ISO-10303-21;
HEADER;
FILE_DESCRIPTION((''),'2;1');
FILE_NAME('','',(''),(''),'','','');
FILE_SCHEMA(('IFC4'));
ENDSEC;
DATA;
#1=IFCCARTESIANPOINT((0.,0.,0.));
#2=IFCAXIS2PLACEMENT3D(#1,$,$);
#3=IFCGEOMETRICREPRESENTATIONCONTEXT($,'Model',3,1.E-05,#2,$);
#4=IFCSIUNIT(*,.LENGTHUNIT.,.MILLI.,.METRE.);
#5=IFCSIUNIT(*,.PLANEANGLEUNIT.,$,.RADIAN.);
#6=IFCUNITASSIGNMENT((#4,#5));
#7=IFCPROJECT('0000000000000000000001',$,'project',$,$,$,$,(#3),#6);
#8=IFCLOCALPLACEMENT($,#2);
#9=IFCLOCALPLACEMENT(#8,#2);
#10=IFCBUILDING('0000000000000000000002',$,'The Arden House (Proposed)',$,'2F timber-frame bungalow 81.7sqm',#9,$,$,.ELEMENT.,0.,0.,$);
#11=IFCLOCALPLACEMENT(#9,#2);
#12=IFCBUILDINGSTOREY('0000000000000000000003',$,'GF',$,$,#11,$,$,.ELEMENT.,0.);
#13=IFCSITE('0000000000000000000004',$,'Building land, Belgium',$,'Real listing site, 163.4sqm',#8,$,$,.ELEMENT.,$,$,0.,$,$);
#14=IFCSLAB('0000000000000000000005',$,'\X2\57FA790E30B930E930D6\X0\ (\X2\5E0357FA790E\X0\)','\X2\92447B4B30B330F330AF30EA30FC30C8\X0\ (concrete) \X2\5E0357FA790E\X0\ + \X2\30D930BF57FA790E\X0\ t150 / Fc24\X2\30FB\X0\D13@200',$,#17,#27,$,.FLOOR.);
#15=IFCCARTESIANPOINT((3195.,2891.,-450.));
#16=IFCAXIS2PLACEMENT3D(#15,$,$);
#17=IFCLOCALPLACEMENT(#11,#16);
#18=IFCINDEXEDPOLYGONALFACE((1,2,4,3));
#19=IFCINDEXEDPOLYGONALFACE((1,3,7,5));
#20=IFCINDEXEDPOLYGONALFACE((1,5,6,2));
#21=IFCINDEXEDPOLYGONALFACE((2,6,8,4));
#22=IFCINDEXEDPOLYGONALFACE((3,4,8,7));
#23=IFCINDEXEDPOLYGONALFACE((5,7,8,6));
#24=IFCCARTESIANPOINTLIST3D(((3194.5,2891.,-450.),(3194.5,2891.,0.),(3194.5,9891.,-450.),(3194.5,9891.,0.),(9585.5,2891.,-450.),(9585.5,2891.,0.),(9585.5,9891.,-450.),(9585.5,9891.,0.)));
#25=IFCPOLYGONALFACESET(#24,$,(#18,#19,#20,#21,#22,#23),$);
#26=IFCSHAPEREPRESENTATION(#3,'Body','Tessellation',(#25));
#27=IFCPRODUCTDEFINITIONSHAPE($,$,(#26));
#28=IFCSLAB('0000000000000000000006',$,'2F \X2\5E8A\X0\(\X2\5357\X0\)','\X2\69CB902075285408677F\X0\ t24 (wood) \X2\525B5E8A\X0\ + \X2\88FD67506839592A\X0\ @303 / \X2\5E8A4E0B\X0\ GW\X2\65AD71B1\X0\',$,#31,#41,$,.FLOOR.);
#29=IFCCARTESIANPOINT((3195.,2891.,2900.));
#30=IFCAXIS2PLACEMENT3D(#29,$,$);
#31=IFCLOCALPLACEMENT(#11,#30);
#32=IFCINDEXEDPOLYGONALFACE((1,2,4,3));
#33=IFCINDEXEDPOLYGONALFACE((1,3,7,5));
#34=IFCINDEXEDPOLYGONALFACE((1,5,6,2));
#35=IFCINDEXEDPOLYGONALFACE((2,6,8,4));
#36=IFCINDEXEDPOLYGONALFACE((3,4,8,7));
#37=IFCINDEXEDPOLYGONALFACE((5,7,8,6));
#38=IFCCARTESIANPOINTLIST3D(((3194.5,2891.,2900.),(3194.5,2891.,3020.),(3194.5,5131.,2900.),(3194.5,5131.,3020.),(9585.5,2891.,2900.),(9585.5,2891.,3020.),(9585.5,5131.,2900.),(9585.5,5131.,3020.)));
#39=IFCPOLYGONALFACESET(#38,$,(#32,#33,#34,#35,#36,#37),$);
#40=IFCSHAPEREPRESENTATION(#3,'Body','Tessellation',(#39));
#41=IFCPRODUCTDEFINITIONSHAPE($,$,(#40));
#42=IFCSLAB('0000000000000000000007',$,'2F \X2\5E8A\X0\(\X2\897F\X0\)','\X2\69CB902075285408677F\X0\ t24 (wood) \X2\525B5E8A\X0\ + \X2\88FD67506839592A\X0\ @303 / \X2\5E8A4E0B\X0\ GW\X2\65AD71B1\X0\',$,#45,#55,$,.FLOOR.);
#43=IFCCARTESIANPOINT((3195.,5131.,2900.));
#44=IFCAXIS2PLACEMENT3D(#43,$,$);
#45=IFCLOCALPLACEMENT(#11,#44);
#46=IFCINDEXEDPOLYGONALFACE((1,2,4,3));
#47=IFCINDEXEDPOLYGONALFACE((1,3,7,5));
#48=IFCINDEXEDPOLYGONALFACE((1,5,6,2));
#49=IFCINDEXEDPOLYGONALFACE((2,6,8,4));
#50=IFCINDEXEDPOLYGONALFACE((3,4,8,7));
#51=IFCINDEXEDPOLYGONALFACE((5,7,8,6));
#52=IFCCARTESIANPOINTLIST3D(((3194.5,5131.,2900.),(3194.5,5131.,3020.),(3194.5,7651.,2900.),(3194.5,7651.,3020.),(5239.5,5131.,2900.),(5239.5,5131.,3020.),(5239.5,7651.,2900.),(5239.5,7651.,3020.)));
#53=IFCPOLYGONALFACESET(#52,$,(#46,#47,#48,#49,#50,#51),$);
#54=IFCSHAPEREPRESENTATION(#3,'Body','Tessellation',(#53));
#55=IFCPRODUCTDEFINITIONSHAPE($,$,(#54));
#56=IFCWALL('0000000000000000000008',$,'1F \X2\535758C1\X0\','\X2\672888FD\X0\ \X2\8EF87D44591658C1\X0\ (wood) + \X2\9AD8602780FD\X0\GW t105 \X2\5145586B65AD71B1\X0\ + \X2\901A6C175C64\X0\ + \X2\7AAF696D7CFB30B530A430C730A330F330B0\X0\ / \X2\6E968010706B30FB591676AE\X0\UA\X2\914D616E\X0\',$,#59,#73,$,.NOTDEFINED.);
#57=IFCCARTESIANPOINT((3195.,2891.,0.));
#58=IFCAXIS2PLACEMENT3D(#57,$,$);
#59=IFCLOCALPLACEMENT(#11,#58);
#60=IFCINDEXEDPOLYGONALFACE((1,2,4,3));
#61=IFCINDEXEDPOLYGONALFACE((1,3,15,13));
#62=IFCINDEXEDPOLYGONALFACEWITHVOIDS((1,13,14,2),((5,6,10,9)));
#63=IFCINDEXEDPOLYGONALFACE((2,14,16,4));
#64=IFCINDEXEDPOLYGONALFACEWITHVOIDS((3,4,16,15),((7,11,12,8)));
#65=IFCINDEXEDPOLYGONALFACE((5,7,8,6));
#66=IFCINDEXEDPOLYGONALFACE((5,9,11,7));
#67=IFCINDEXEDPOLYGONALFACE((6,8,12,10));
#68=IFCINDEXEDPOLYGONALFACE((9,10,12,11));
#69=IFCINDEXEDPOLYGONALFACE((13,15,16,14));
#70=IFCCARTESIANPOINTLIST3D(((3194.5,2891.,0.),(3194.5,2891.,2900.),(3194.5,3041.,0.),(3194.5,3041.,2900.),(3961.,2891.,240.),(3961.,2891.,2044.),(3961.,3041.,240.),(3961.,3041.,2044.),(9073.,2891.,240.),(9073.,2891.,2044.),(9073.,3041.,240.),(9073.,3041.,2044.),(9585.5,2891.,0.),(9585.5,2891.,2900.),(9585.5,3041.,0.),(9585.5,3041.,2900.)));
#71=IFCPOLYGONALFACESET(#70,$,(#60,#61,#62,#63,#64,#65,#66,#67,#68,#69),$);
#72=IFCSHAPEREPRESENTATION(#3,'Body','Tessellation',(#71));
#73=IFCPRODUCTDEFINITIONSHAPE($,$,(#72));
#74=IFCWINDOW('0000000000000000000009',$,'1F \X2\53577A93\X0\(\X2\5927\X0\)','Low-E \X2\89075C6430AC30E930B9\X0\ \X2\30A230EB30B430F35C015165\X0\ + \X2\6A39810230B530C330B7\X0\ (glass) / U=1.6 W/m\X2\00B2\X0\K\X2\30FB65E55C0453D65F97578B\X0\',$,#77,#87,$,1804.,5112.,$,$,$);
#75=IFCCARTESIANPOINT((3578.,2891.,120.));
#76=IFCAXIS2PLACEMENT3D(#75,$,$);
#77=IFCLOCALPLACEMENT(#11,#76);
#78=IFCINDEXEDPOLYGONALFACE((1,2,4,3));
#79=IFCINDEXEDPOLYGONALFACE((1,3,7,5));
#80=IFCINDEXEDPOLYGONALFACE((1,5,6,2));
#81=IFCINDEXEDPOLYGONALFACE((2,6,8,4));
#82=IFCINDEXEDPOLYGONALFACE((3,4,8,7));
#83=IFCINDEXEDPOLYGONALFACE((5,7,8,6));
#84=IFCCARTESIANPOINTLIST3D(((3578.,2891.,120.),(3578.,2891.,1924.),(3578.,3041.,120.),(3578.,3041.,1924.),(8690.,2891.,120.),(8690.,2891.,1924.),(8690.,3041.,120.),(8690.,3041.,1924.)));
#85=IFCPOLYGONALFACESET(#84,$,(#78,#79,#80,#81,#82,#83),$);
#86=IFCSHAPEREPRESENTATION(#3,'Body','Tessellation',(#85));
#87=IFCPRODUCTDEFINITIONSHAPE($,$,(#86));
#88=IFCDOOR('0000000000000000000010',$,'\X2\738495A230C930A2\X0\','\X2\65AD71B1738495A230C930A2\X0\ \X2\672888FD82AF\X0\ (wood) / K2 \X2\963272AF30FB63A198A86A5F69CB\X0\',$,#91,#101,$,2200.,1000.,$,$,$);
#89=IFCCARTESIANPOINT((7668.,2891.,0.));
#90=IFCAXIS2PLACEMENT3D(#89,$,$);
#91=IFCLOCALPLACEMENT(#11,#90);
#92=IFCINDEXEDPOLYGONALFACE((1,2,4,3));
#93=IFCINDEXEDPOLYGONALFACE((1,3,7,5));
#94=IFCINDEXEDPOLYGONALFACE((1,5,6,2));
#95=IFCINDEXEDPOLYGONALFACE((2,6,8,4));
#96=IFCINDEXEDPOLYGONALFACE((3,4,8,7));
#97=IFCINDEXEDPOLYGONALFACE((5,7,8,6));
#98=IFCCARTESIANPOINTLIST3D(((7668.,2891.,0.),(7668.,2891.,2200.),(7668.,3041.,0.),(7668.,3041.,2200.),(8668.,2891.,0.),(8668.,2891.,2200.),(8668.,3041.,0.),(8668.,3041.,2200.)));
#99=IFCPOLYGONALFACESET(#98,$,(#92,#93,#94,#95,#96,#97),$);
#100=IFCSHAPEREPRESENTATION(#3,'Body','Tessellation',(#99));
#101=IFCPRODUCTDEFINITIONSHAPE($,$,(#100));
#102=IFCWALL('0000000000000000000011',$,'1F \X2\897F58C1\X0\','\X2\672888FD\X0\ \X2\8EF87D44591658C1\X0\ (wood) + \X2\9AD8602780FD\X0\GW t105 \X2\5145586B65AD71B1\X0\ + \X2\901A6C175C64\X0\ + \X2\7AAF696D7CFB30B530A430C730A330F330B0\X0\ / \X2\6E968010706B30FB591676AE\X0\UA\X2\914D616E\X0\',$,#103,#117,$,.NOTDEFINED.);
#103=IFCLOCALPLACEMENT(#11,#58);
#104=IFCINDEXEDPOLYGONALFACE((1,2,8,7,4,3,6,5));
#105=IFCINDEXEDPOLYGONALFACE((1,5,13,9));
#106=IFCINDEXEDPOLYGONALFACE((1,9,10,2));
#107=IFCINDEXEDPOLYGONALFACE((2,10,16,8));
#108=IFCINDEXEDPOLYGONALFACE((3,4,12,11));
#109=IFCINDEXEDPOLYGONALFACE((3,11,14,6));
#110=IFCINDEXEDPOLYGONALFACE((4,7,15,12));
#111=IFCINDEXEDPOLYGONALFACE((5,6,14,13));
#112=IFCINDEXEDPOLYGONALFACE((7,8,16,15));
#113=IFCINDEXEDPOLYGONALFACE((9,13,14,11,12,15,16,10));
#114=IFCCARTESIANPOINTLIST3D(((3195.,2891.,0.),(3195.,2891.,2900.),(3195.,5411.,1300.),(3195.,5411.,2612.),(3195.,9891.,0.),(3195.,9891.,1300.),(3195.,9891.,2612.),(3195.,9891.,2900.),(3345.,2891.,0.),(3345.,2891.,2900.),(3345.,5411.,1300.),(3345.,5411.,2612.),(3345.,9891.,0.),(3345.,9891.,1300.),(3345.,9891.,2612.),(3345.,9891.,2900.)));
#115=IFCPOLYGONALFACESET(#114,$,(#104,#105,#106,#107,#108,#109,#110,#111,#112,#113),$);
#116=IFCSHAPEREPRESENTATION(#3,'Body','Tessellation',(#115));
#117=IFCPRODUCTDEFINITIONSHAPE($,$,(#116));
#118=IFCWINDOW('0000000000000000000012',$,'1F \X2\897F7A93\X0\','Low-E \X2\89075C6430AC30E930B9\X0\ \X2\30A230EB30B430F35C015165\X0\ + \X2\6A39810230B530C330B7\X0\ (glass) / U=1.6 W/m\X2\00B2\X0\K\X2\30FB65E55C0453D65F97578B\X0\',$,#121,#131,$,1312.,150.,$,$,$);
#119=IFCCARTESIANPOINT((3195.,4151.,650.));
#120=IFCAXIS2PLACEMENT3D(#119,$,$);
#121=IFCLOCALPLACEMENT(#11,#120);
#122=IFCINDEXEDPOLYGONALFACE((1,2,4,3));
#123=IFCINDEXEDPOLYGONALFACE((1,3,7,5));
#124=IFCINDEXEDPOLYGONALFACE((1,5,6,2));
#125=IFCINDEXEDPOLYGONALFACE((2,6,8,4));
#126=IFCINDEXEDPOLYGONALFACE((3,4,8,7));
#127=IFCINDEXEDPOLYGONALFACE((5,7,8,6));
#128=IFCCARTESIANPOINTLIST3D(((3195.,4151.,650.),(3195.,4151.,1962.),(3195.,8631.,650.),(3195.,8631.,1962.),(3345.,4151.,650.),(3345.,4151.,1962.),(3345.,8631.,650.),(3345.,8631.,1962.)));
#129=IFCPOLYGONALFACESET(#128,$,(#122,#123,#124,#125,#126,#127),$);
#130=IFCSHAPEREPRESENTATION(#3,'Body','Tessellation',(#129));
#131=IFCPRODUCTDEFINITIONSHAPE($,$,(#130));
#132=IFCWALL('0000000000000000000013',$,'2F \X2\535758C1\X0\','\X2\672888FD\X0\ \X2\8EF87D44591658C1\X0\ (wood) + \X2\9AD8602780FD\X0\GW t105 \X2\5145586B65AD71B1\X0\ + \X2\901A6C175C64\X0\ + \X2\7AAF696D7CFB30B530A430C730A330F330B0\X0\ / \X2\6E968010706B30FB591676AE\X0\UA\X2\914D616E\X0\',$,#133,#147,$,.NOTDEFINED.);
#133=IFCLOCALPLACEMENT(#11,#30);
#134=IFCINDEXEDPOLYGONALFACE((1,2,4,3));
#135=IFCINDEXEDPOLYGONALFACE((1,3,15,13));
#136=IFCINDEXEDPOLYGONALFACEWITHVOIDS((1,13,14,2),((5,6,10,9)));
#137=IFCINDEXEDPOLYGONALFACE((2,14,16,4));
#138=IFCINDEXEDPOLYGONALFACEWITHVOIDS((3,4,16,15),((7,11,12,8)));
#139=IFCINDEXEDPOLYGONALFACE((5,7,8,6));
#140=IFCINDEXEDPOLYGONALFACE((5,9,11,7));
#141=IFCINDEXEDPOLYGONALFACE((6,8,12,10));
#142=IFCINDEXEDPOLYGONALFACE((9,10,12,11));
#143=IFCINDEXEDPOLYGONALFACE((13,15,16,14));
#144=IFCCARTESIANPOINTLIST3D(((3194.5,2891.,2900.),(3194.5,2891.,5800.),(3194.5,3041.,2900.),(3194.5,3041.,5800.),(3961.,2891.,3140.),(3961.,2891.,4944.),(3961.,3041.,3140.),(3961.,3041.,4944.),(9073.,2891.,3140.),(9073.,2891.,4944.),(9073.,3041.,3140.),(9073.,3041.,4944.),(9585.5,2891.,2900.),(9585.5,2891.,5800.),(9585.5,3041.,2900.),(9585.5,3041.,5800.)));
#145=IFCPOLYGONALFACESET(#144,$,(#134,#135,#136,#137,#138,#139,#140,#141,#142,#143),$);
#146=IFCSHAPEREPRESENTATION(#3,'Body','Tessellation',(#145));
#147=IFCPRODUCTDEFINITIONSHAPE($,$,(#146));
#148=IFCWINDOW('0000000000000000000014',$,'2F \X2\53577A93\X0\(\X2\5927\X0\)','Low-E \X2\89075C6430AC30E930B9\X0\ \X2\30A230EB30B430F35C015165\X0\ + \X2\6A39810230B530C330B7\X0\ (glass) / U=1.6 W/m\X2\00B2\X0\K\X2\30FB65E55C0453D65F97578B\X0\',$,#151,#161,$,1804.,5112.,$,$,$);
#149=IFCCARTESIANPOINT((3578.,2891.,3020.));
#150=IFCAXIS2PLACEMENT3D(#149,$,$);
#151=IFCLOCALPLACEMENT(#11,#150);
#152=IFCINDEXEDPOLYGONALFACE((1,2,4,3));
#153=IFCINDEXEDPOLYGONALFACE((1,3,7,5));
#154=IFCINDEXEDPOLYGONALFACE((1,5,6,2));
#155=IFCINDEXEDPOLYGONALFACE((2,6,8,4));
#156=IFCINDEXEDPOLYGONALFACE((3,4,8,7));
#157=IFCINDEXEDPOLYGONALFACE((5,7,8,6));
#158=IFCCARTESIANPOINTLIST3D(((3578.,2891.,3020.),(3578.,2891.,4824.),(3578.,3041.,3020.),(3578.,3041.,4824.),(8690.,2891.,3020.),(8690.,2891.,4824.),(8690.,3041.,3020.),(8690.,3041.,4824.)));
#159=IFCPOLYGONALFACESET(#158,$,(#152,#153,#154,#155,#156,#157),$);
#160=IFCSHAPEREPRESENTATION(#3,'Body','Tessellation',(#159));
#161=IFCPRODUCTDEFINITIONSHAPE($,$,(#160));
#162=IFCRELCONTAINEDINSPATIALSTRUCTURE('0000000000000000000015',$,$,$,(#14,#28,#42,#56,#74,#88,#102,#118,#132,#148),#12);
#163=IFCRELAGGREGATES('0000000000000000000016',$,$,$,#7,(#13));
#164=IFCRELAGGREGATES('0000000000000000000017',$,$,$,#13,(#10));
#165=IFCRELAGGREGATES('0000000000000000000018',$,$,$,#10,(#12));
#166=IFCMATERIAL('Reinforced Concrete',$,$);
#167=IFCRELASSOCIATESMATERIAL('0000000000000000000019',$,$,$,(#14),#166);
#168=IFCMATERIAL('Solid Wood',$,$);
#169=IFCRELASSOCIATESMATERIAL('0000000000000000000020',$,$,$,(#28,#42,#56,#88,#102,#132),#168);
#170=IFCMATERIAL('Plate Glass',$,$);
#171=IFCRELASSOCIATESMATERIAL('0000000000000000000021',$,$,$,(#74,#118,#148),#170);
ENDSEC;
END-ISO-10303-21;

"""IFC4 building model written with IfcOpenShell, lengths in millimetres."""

from ifc_helpers import new_model, si_unit, frame, frame_2d, origin, place, context, project, spatial, rectangle, extrude, material, element, fill, save


model = new_model("IFC4")

# Units and contexts
model_context = context("Model", 3, precision=1e-05, world=origin())
ifc_project = project(units=[si_unit("LENGTHUNIT", "METRE", prefix="MILLI"), si_unit("PLANEANGLEUNIT", "RADIAN")], contexts=[model_context])

# Site, building, storey
site_placement = place(None, origin())
site = spatial("IfcSite", under=ifc_project, at=site_placement, Name="Building land, Belgium", ObjectType="Real listing site, 163.4sqm", CompositionType="ELEMENT", RefElevation=0.0)
building_placement = place(site_placement, origin())
building = spatial("IfcBuilding", under=site, at=building_placement, Name="The Arden House (Proposed)", ObjectType="2F timber-frame bungalow 81.7sqm", CompositionType="ELEMENT", ElevationOfRefHeight=0.0, ElevationOfTerrain=0.0)
storey_placement = place(building_placement, origin())
storey = spatial("IfcBuildingStorey", under=building, at=storey_placement, Name="GF", CompositionType="ELEMENT", Elevation=0.0)

# Slabs
ifc_material_1 = material(Name="Reinforced Concrete")
slab_1_placement = place(storey_placement, frame((3195.0, 2891.0, -450.0)))
element("IfcSlab", 1, at=slab_1_placement, inside=storey, material=ifc_material_1, Name="基礎スラブ (布基礎)", Description="鉄筋コンクリート (concrete) 布基礎 + ベタ基礎 t150 / Fc24・D13@200", PredefinedType="FLOOR", context=model_context, shape_type="SweptSolid", body=[
    extrude(rectangle(XDim=6391.0, YDim=7000.0, at=frame_2d((3195.0, 3500.0))), frame((3195.0, 2891.0, -450.0)), (0.0, 0.0, 1.0), 450.0),
])
ifc_material_2 = material(Name="Solid Wood")
slab_2_placement = place(storey_placement, frame((3195.0, 2891.0, 2900.0)))
element("IfcSlab", 2, at=slab_2_placement, inside=storey, material=ifc_material_2, Name="2F 床(南)", Description="構造用合板 t24 (wood) 剛床 + 製材根太 @303 / 床下 GW断熱", PredefinedType="FLOOR", context=model_context, shape_type="SweptSolid", body=[
    extrude(rectangle(XDim=6391.0, YDim=2240.0, at=frame_2d((3195.0, 1120.0))), frame((3195.0, 2891.0, 2900.0)), (0.0, 0.0, 1.0), 120.0),
])
slab_3_placement = place(storey_placement, frame((3195.0, 5131.0, 2900.0)))
element("IfcSlab", 3, at=slab_3_placement, inside=storey, material=ifc_material_2, Name="2F 床(西)", Description="構造用合板 t24 (wood) 剛床 + 製材根太 @303 / 床下 GW断熱", PredefinedType="FLOOR", context=model_context, shape_type="SweptSolid", body=[
    extrude(rectangle(XDim=2045.0, YDim=2520.0, at=frame_2d((1022.0, 1260.0))), frame((3195.0, 5131.0, 2900.0)), (0.0, 0.0, 1.0), 120.0),
])

# Wall, openings, window, door
wall_1_placement = place(storey_placement, frame((3195.0, 2891.0, 0.0)))
wall_1 = element("IfcWall", 4, at=wall_1_placement, inside=storey, material=ifc_material_2, Name="1F 南壁", Description="木製 軸組外壁 (wood) + 高性能GW t105 充填断熱 + 通気層 + 窯業系サイディング / 準耐火・外皮UA配慮", PredefinedType="NOTDEFINED", context=model_context, shape_type="SweptSolid", body=[
    extrude(rectangle(XDim=6391.0, YDim=150.0, at=frame_2d((3195.0, 75.0))), frame((3195.0, 2891.0, 0.0)), (0.0, 0.0, 1.0), 2900.0),
])
opening_1_placement = place(storey_placement, frame((3578.0, 2891.0, 120.0)))
opening_1 = element("IfcOpeningElement", 5, at=opening_1_placement, cuts=wall_1, PredefinedType="NOTDEFINED", context=model_context, shape_type="SweptSolid", body=[
    extrude(rectangle(XDim=5112.0, YDim=150.0, at=frame_2d((2556.0, 75.0))), frame((3578.0, 2891.0, 120.0)), (0.0, 0.0, 1.0), 1804.0),
])
opening_2_placement = place(storey_placement, frame((7668.0, 2891.0, 0.0)))
opening_2 = element("IfcOpeningElement", 6, at=opening_2_placement, cuts=wall_1, PredefinedType="NOTDEFINED", context=model_context, shape_type="SweptSolid", body=[
    extrude(rectangle(XDim=1000.0, YDim=150.0, at=frame_2d((500.0, 75.0))), frame((7668.0, 2891.0, 0.0)), (0.0, 0.0, 1.0), 2200.0),
])
ifc_material_3 = material(Name="Plate Glass")
window_1_placement = place(storey_placement, frame((3578.0, 2891.0, 120.0)))
window_1 = element("IfcWindow", 7, at=window_1_placement, inside=storey, material=ifc_material_3, Name="1F 南窓(大)", Description="Low-E 複層ガラス アルゴン封入 + 樹脂サッシ (glass) / U=1.6 W/m²K・日射取得型", OverallHeight=1804.0, OverallWidth=5112.0, context=model_context, shape_type="SweptSolid", body=[
    extrude(rectangle(XDim=5112.0, YDim=150.0, at=frame_2d((2556.0, 75.0))), frame((3578.0, 2891.0, 120.0)), (0.0, 0.0, 1.0), 1804.0),
])
fill(opening_1, window_1)
door_placement = place(storey_placement, frame((7668.0, 2891.0, 0.0)))
door = element("IfcDoor", 8, at=door_placement, inside=storey, material=ifc_material_2, Name="玄関ドア", Description="断熱玄関ドア 木製芯 (wood) / K2 防犯・採風機構", OverallHeight=2200.0, OverallWidth=1000.0, context=model_context, shape_type="SweptSolid", body=[
    extrude(rectangle(XDim=1000.0, YDim=150.0, at=frame_2d((500.0, 75.0))), frame((7668.0, 2891.0, 0.0)), (0.0, 0.0, 1.0), 2200.0),
])
fill(opening_2, door)

# Walls, openings, windows
wall_2_placement = place(storey_placement, frame((3195.0, 2891.0, 0.0)))
wall_2 = element("IfcWall", 9, at=wall_2_placement, inside=storey, material=ifc_material_2, Name="1F 西壁", Description="木製 軸組外壁 (wood) + 高性能GW t105 充填断熱 + 通気層 + 窯業系サイディング / 準耐火・外皮UA配慮", PredefinedType="NOTDEFINED", context=model_context, shape_type="SweptSolid", body=[
    extrude(rectangle(XDim=150.0, YDim=7000.0, at=frame_2d((75.0, 3500.0))), frame((3195.0, 2891.0, 0.0)), (0.0, 0.0, 1.0), 2900.0),
])
opening_3_placement = place(storey_placement, frame((3195.0, 4151.0, 650.0)))
opening_3 = element("IfcOpeningElement", 10, at=opening_3_placement, cuts=wall_2, PredefinedType="NOTDEFINED", context=model_context, shape_type="SweptSolid", body=[
    extrude(rectangle(XDim=150.0, YDim=4480.0, at=frame_2d((75.0, 2240.0))), frame((3195.0, 4151.0, 650.0)), (0.0, 0.0, 1.0), 1312.0),
])
window_2_placement = place(storey_placement, frame((3195.0, 4151.0, 650.0)))
window_2 = element("IfcWindow", 11, at=window_2_placement, inside=storey, material=ifc_material_3, Name="1F 西窓", Description="Low-E 複層ガラス アルゴン封入 + 樹脂サッシ (glass) / U=1.6 W/m²K・日射取得型", OverallHeight=1312.0, OverallWidth=150.0, context=model_context, shape_type="SweptSolid", body=[
    extrude(rectangle(XDim=150.0, YDim=4480.0, at=frame_2d((75.0, 2240.0))), frame((3195.0, 4151.0, 650.0)), (0.0, 0.0, 1.0), 1312.0),
])
fill(opening_3, window_2)
wall_3_placement = place(storey_placement, frame((3195.0, 2891.0, 2900.0)))
wall_3 = element("IfcWall", 12, at=wall_3_placement, inside=storey, material=ifc_material_2, Name="2F 南壁", Description="木製 軸組外壁 (wood) + 高性能GW t105 充填断熱 + 通気層 + 窯業系サイディング / 準耐火・外皮UA配慮", PredefinedType="NOTDEFINED", context=model_context, shape_type="SweptSolid", body=[
    extrude(rectangle(XDim=6391.0, YDim=150.0, at=frame_2d((3195.0, 75.0))), frame((3195.0, 2891.0, 2900.0)), (0.0, 0.0, 1.0), 2900.0),
])
opening_4_placement = place(storey_placement, frame((3578.0, 2891.0, 3020.0)))
opening_4 = element("IfcOpeningElement", 13, at=opening_4_placement, cuts=wall_3, PredefinedType="NOTDEFINED", context=model_context, shape_type="SweptSolid", body=[
    extrude(rectangle(XDim=5112.0, YDim=150.0, at=frame_2d((2556.0, 75.0))), frame((3578.0, 2891.0, 3020.0)), (0.0, 0.0, 1.0), 1804.0),
])
window_3_placement = place(storey_placement, frame((3578.0, 2891.0, 3020.0)))
window_3 = element("IfcWindow", 14, at=window_3_placement, inside=storey, material=ifc_material_3, Name="2F 南窓(大)", Description="Low-E 複層ガラス アルゴン封入 + 樹脂サッシ (glass) / U=1.6 W/m²K・日射取得型", OverallHeight=1804.0, OverallWidth=5112.0, context=model_context, shape_type="SweptSolid", body=[
    extrude(rectangle(XDim=5112.0, YDim=150.0, at=frame_2d((2556.0, 75.0))), frame((3578.0, 2891.0, 3020.0)), (0.0, 0.0, 1.0), 1804.0),
])
fill(opening_4, window_3)

save(model, "model.ifc")
